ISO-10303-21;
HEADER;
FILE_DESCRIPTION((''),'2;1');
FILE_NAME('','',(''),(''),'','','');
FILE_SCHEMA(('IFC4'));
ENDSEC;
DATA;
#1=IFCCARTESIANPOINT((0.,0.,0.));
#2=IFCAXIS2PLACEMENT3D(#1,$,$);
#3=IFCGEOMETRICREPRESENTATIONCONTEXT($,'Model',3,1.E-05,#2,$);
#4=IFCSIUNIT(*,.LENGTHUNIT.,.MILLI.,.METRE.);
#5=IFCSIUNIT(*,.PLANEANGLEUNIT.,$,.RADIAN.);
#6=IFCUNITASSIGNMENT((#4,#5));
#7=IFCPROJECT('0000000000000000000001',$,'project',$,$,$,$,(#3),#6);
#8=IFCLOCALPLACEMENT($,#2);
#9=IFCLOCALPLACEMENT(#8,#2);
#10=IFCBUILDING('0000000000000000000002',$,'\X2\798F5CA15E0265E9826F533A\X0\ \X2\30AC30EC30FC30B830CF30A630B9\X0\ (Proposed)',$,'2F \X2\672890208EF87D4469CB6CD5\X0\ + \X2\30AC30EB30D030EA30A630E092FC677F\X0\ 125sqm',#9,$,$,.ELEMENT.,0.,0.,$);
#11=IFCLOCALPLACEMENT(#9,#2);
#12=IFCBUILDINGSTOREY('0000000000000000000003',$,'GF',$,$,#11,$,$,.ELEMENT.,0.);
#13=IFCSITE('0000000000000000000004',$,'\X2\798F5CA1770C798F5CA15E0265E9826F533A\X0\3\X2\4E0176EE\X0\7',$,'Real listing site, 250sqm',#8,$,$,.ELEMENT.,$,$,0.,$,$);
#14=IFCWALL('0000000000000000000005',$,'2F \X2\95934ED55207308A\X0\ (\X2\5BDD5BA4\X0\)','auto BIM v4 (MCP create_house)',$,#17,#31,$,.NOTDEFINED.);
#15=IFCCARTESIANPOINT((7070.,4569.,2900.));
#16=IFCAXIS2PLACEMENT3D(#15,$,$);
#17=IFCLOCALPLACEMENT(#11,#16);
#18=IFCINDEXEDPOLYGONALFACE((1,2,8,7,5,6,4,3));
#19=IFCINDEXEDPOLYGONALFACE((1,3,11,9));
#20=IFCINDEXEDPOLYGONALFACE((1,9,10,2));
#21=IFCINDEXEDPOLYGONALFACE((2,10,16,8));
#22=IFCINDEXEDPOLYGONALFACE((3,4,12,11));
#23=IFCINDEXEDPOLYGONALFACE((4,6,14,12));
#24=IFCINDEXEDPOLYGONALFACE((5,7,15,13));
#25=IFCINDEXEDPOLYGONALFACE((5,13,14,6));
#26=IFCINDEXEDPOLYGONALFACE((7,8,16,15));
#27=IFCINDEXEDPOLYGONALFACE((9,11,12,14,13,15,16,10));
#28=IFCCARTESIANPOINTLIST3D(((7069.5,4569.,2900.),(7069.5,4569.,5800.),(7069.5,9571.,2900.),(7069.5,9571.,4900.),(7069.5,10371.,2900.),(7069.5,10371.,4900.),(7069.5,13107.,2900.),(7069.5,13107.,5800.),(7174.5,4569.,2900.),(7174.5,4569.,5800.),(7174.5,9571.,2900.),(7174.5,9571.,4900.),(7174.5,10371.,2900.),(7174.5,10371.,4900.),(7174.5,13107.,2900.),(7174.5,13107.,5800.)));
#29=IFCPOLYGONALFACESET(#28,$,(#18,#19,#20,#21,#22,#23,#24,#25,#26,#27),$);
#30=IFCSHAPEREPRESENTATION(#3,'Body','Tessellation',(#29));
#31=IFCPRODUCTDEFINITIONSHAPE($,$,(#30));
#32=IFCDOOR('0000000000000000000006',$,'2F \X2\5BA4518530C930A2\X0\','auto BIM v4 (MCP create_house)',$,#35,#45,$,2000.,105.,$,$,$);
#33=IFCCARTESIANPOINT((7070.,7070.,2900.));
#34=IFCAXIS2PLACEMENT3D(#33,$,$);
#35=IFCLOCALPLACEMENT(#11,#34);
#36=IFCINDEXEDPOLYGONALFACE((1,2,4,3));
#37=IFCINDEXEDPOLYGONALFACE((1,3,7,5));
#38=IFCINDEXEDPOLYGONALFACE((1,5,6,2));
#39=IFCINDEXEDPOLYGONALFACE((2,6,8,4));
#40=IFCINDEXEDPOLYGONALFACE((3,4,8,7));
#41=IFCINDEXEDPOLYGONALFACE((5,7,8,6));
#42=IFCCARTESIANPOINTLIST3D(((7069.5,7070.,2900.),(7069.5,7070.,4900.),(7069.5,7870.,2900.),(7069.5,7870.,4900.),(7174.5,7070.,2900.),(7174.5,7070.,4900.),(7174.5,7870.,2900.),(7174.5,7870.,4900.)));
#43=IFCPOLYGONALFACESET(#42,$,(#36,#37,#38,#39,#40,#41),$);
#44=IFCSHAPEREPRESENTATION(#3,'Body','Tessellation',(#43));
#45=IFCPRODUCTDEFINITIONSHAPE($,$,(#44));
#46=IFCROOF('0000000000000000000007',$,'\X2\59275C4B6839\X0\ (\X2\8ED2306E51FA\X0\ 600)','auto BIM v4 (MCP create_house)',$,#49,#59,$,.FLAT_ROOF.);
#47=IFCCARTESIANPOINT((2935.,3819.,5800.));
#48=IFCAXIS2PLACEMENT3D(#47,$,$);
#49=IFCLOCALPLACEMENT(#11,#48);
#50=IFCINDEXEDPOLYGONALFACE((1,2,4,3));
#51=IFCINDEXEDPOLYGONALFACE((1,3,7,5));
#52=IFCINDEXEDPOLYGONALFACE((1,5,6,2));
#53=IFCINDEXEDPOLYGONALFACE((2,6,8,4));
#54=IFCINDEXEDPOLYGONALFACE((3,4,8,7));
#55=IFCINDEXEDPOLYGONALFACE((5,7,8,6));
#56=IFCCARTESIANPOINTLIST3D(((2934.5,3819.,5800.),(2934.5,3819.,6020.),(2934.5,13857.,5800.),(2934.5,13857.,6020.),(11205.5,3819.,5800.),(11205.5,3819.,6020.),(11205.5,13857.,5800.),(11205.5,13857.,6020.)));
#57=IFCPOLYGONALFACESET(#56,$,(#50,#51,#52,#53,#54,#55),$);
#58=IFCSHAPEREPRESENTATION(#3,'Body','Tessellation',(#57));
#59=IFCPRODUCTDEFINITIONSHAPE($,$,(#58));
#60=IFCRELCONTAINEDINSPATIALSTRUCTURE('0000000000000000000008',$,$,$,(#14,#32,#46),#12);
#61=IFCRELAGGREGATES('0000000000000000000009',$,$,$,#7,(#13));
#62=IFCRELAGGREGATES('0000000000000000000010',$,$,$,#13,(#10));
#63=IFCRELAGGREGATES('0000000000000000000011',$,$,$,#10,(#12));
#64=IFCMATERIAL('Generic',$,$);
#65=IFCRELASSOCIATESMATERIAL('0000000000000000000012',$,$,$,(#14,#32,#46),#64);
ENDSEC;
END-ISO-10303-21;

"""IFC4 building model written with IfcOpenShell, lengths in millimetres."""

from ifc_helpers import new_model, si_unit, frame, frame_2d, origin, place, context, project, spatial, rectangle, extrude, material, element, fill, save


model = new_model("IFC4")

# Units and contexts
model_context = context("Model", 3, precision=1e-05, world=origin())
ifc_project = project(units=[si_unit("LENGTHUNIT", "METRE", prefix="MILLI"), si_unit("PLANEANGLEUNIT", "RADIAN")], contexts=[model_context])

# Site, building, storey
site_placement = place(None, origin())
site = spatial("IfcSite", under=ifc_project, at=site_placement, Name="福岡県福岡市早良区3丁目7", ObjectType="Real listing site, 250sqm", CompositionType="ELEMENT", RefElevation=0.0)
building_placement = place(site_placement, origin())
building = spatial("IfcBuilding", under=site, at=building_placement, Name="福岡市早良区 ガレージハウス (Proposed)", ObjectType="2F 木造軸組構法 + ガルバリウム鋼板 125sqm", CompositionType="ELEMENT", ElevationOfRefHeight=0.0, ElevationOfTerrain=0.0)
storey_placement = place(building_placement, origin())
storey = spatial("IfcBuildingStorey", under=building, at=storey_placement, Name="GF", CompositionType="ELEMENT", Elevation=0.0)

# Shared definitions
ifc_material = material(Name="Generic")

# Wall, opening, door
wall_1_placement = place(storey_placement, frame((7070.0, 4569.0, 2900.0)))
wall_1 = element("IfcWall", 1, at=wall_1_placement, inside=storey, material=ifc_material, Name="2F 間仕切り (寝室)", Description="auto BIM v4 (MCP create_house)", PredefinedType="NOTDEFINED", context=model_context, shape_type="SweptSolid", body=[
    extrude(rectangle(XDim=105.0, YDim=8538.0, at=frame_2d((52.0, 4269.0))), frame((7070.0, 4569.0, 2900.0)), (0.0, 0.0, 1.0), 2900.0),
])
opening_1_placement = place(storey_placement, frame((7070.0, 7070.0, 2900.0)))
opening_1 = element("IfcOpeningElement", 2, at=opening_1_placement, cuts=wall_1, PredefinedType="NOTDEFINED", context=model_context, shape_type="SweptSolid", body=[
    extrude(rectangle(XDim=105.0, YDim=800.0, at=frame_2d((52.0, 400.0))), frame((7070.0, 7070.0, 2900.0)), (0.0, 0.0, 1.0), 2000.0),
])
door_1_placement = place(storey_placement, frame((7070.0, 7070.0, 2900.0)))
door_1 = element("IfcDoor", 3, at=door_1_placement, inside=storey, material=ifc_material, Name="2F 室内ドア", Description="auto BIM v4 (MCP create_house)", OverallHeight=2000.0, OverallWidth=105.0, context=model_context, shape_type="SweptSolid", body=[
    extrude(rectangle(XDim=105.0, YDim=800.0, at=frame_2d((52.0, 400.0))), frame((7070.0, 7070.0, 2900.0)), (0.0, 0.0, 1.0), 2000.0),
])
fill(opening_1, door_1)

# Roof
roof_placement = place(storey_placement, frame((2935.0, 3819.0, 5800.0)))
element("IfcRoof", 4, at=roof_placement, inside=storey, material=ifc_material, Name="大屋根 (軒の出 600)", Description="auto BIM v4 (MCP create_house)", PredefinedType="FLAT_ROOF", context=model_context, shape_type="SweptSolid", body=[
    extrude(rectangle(XDim=8271.0, YDim=10038.0, at=frame_2d((4135.0, 5019.0))), frame((2935.0, 3819.0, 5800.0)), (0.0, 0.0, 1.0), 220.0),
])

save(model, "model.ifc")
